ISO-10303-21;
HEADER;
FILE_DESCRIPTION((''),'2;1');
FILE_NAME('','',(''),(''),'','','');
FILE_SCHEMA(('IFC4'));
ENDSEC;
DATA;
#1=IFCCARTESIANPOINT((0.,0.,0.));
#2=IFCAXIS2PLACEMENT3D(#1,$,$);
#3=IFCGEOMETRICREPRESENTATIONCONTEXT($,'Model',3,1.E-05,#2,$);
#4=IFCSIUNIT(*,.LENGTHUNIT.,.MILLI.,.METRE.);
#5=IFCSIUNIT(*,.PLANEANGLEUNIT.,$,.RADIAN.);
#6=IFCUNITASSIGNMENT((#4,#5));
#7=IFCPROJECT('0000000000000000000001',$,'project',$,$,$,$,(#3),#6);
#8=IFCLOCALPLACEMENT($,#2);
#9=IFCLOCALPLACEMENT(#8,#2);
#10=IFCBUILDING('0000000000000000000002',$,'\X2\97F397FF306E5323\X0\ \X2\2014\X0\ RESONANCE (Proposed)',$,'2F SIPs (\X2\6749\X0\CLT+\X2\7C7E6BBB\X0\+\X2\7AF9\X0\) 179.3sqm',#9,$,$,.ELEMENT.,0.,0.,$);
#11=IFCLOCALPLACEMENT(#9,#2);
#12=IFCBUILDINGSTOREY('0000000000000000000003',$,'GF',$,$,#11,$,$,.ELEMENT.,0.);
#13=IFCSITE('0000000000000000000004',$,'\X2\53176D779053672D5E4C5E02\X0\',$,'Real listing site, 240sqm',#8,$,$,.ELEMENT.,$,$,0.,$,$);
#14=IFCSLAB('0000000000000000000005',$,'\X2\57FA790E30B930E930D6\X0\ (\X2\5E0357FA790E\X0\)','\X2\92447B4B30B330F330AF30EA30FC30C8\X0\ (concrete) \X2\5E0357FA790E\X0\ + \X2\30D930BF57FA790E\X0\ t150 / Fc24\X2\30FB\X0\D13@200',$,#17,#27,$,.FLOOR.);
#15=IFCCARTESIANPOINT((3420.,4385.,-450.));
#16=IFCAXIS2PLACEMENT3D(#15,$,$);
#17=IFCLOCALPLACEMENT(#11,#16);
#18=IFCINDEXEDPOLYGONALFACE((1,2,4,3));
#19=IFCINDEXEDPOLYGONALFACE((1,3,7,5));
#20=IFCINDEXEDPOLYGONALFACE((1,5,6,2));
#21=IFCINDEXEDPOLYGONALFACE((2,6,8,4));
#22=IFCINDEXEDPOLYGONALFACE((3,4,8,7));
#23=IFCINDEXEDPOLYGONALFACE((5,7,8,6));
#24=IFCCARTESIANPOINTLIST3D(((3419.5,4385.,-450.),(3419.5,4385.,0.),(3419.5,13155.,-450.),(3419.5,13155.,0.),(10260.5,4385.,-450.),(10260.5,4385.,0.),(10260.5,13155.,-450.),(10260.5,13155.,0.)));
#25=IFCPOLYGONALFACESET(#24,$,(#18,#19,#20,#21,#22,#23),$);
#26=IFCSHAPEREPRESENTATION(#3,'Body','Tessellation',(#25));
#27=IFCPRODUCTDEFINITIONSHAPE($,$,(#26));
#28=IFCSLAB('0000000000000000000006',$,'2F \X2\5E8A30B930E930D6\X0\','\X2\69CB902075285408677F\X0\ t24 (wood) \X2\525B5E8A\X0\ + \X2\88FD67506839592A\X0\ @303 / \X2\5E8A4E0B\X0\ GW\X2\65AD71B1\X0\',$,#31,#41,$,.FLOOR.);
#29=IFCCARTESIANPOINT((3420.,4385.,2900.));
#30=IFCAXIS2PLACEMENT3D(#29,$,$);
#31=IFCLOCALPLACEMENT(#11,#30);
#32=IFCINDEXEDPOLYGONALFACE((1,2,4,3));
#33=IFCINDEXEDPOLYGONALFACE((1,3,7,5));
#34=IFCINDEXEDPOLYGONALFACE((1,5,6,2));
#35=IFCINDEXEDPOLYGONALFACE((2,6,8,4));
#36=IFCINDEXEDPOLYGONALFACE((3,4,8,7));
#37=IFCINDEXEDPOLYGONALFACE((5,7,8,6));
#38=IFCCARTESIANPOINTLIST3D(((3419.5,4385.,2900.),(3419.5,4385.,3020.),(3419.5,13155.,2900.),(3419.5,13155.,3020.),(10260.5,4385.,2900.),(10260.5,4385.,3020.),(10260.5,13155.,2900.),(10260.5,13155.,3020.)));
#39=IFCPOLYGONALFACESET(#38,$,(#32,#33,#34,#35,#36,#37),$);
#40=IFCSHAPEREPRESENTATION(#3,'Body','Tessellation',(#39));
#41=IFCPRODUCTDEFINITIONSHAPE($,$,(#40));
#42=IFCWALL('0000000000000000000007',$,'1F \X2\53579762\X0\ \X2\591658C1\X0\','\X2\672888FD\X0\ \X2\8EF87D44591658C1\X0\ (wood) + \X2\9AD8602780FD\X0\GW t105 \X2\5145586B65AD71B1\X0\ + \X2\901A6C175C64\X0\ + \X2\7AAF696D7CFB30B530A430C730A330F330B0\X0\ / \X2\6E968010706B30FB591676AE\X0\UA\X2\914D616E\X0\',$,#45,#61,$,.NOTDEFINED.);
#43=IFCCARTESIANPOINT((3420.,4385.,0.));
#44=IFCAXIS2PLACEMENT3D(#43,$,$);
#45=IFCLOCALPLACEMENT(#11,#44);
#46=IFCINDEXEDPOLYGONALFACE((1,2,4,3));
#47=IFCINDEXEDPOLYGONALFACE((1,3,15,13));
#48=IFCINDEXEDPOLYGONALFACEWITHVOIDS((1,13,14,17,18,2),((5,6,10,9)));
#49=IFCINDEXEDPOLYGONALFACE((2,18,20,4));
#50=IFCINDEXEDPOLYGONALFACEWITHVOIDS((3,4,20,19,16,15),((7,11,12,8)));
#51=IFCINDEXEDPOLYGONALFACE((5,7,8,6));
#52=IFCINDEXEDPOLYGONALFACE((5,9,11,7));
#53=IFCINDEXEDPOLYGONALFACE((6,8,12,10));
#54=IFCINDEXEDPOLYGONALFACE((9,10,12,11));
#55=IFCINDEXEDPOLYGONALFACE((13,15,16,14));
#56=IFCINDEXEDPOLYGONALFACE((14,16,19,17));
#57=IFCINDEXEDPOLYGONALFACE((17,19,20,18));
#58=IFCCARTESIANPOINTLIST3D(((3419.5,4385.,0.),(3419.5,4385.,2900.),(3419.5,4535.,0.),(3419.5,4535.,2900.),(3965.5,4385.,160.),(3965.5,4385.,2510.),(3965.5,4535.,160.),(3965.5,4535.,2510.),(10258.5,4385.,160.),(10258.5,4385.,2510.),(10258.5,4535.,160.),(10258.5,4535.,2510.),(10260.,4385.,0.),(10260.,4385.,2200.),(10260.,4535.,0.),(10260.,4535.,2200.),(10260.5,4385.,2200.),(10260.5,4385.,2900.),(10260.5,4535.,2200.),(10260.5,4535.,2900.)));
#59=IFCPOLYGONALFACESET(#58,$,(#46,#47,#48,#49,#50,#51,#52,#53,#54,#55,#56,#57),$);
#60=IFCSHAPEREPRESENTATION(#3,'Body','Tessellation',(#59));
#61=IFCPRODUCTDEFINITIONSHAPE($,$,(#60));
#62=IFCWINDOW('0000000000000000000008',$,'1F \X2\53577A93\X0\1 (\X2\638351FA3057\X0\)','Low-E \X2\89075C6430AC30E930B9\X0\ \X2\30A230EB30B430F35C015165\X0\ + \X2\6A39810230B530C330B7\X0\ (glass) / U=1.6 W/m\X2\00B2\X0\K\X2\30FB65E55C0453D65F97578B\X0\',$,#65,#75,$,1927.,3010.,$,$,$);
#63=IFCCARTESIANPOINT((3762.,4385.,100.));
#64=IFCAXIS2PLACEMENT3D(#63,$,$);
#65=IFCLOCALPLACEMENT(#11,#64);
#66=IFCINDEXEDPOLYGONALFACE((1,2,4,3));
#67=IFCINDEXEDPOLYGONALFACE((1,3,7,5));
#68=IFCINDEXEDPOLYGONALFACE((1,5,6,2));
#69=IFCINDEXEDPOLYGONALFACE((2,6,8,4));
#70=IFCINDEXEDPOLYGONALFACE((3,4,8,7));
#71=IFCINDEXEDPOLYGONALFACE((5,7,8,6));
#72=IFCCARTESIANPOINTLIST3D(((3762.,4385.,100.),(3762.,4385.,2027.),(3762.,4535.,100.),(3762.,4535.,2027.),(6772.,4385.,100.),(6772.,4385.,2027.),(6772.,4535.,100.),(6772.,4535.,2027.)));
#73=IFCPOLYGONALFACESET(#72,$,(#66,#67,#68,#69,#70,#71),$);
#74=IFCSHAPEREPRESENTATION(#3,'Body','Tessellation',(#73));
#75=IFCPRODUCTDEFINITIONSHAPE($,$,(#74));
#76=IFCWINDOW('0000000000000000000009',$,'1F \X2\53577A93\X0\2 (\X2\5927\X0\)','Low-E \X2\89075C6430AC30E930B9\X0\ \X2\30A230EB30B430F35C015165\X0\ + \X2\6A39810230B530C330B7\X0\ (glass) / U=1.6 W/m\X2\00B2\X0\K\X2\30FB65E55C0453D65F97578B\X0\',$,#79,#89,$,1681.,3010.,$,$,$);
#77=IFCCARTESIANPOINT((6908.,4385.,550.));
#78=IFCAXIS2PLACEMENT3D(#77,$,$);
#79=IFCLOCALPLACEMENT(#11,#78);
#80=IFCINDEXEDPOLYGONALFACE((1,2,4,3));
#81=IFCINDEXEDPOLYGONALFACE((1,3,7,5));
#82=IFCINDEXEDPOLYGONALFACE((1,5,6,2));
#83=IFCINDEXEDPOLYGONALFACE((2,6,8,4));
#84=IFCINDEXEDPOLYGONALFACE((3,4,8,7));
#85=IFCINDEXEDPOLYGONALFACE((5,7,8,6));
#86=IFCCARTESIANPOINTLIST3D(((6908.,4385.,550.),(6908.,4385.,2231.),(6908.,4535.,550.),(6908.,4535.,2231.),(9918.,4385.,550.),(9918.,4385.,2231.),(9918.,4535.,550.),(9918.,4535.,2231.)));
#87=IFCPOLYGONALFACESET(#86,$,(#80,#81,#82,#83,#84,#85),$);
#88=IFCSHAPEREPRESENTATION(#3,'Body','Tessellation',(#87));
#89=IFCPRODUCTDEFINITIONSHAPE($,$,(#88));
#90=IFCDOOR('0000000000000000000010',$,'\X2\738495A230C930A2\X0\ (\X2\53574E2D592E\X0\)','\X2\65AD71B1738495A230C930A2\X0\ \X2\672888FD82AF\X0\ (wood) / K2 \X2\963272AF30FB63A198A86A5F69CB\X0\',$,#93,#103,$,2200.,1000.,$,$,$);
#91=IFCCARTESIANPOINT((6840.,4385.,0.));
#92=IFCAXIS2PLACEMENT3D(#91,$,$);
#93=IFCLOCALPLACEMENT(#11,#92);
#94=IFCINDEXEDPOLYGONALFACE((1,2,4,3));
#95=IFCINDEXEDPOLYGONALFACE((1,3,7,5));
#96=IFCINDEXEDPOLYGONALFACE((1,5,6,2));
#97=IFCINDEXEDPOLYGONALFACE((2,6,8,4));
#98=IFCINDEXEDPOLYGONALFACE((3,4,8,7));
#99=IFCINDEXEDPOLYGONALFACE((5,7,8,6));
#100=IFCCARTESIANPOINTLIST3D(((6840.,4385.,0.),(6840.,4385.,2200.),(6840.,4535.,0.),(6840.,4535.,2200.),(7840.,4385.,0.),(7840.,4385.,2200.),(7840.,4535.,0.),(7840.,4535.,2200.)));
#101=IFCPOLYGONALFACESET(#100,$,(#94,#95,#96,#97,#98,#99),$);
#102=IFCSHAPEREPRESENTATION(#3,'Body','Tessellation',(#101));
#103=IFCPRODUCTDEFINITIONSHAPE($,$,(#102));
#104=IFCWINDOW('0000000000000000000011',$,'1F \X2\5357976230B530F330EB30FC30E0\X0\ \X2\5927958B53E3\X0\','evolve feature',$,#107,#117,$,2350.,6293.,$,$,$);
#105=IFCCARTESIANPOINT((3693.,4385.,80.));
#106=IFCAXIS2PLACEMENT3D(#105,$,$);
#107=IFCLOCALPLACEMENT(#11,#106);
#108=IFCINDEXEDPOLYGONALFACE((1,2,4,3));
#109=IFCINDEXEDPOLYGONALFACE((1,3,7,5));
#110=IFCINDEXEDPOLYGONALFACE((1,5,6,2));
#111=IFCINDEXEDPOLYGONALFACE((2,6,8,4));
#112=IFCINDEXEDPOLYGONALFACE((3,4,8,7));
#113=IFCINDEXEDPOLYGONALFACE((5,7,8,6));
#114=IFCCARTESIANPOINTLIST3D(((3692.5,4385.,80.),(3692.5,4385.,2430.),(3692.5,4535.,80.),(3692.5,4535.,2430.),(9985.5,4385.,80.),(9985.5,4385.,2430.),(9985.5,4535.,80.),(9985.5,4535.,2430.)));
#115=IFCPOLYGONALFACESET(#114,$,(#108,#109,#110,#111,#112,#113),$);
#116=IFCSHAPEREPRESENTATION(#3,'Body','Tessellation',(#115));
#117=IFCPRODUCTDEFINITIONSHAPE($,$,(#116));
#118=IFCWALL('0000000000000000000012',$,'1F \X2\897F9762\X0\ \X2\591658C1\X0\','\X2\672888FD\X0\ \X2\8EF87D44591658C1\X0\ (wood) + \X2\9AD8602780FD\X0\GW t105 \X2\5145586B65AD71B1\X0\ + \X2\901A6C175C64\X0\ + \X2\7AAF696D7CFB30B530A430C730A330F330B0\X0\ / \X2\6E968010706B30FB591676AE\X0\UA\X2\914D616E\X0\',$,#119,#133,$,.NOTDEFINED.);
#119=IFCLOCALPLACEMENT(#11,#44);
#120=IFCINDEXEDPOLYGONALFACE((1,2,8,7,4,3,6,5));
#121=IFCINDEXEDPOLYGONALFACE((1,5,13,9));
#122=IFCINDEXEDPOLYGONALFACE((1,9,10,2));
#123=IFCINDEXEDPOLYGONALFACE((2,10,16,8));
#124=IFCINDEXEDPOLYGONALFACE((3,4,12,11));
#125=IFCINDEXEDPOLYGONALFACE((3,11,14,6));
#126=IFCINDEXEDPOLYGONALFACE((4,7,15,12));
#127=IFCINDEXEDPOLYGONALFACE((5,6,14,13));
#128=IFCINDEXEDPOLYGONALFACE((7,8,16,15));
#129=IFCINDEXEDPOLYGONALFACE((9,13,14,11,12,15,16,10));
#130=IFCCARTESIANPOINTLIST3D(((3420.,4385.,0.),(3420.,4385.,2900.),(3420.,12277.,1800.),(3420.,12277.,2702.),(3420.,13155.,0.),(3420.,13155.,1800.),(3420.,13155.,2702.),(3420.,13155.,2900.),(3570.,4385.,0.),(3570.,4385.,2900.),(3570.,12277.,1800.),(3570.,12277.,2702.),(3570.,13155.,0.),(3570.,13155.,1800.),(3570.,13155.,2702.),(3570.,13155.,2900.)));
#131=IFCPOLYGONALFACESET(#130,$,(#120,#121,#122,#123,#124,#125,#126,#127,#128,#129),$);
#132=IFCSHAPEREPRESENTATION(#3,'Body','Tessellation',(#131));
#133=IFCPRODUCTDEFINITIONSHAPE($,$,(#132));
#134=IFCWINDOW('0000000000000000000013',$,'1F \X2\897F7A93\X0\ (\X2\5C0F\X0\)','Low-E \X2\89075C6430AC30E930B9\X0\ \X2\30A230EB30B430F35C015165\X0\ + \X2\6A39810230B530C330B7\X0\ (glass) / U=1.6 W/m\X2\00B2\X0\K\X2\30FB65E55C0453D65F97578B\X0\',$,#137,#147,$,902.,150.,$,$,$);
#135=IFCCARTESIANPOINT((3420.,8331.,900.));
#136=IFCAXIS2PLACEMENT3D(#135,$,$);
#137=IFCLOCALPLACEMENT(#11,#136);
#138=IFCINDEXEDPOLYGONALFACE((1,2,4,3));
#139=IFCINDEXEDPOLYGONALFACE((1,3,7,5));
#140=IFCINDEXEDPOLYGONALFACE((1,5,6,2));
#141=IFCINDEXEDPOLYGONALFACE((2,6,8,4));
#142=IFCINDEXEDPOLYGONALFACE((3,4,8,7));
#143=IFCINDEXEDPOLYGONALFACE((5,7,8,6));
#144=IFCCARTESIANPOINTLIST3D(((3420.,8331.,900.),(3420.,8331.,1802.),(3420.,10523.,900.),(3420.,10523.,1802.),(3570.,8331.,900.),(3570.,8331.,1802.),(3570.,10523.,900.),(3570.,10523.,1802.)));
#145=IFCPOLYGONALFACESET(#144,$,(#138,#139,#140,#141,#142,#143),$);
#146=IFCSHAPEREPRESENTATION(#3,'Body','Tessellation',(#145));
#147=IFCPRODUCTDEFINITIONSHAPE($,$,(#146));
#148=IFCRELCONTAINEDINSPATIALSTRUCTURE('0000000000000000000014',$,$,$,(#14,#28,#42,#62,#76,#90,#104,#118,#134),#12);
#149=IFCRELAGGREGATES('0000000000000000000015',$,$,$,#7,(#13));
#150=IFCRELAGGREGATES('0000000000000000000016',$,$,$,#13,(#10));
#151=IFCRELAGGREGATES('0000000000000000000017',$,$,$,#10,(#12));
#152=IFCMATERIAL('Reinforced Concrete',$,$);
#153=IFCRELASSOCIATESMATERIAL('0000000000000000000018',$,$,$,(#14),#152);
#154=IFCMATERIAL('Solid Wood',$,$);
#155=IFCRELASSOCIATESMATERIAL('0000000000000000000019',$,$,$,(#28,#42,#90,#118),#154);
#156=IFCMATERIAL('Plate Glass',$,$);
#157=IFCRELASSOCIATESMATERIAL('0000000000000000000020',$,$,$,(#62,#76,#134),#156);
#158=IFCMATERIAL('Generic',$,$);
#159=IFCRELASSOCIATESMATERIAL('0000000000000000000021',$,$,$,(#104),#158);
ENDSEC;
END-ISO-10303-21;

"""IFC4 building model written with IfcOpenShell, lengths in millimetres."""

from ifc_helpers import new_model, si_unit, frame, frame_2d, origin, place, context, project, spatial, rectangle, extrude, material, element, fill, save


model = new_model("IFC4")

# Units and contexts
model_context = context("Model", 3, precision=1e-05, world=origin())
ifc_project = project(units=[si_unit("LENGTHUNIT", "METRE", prefix="MILLI"), si_unit("PLANEANGLEUNIT", "RADIAN")], contexts=[model_context])

# Site, building, storey
site_placement = place(None, origin())
site = spatial("IfcSite", under=ifc_project, at=site_placement, Name="北海道札幌市", ObjectType="Real listing site, 240sqm", CompositionType="ELEMENT", RefElevation=0.0)
building_placement = place(site_placement, origin())
building = spatial("IfcBuilding", under=site, at=building_placement, Name="音響の匣 — RESONANCE (Proposed)", ObjectType="2F SIPs (杉CLT+籾殻+竹) 179.3sqm", CompositionType="ELEMENT", ElevationOfRefHeight=0.0, ElevationOfTerrain=0.0)
storey_placement = place(building_placement, origin())
storey = spatial("IfcBuildingStorey", under=building, at=storey_placement, Name="GF", CompositionType="ELEMENT", Elevation=0.0)

# Slabs
ifc_material_1 = material(Name="Reinforced Concrete")
slab_1_placement = place(storey_placement, frame((3420.0, 4385.0, -450.0)))
element("IfcSlab", 1, at=slab_1_placement, inside=storey, material=ifc_material_1, Name="基礎スラブ (布基礎)", Description="鉄筋コンクリート (concrete) 布基礎 + ベタ基礎 t150 / Fc24・D13@200", PredefinedType="FLOOR", context=model_context, shape_type="SweptSolid", body=[
    extrude(rectangle(XDim=6841.0, YDim=8770.0, at=frame_2d((3420.0, 4385.0))), frame((3420.0, 4385.0, -450.0)), (0.0, 0.0, 1.0), 450.0),
])
ifc_material_2 = material(Name="Solid Wood")
slab_2_placement = place(storey_placement, frame((3420.0, 4385.0, 2900.0)))
element("IfcSlab", 2, at=slab_2_placement, inside=storey, material=ifc_material_2, Name="2F 床スラブ", Description="構造用合板 t24 (wood) 剛床 + 製材根太 @303 / 床下 GW断熱", PredefinedType="FLOOR", context=model_context, shape_type="SweptSolid", body=[
    extrude(rectangle(XDim=6841.0, YDim=8770.0, at=frame_2d((3420.0, 4385.0))), frame((3420.0, 4385.0, 2900.0)), (0.0, 0.0, 1.0), 120.0),
])

# Wall, openings, windows, door
wall_1_placement = place(storey_placement, frame((3420.0, 4385.0, 0.0)))
wall_1 = element("IfcWall", 3, at=wall_1_placement, inside=storey, material=ifc_material_2, Name="1F 南面 外壁", Description="木製 軸組外壁 (wood) + 高性能GW t105 充填断熱 + 通気層 + 窯業系サイディング / 準耐火・外皮UA配慮", PredefinedType="NOTDEFINED", context=model_context, shape_type="SweptSolid", body=[
    extrude(rectangle(XDim=6841.0, YDim=150.0, at=frame_2d((3420.0, 75.0))), frame((3420.0, 4385.0, 0.0)), (0.0, 0.0, 1.0), 2900.0),
])
opening_1_placement = place(storey_placement, frame((3762.0, 4385.0, 100.0)))
opening_1 = element("IfcOpeningElement", 4, at=opening_1_placement, cuts=wall_1, PredefinedType="NOTDEFINED", context=model_context, shape_type="SweptSolid", body=[
    extrude(rectangle(XDim=3010.0, YDim=150.0, at=frame_2d((1505.0, 75.0))), frame((3762.0, 4385.0, 100.0)), (0.0, 0.0, 1.0), 1927.0),
])
opening_2_placement = place(storey_placement, frame((6908.0, 4385.0, 550.0)))
opening_2 = element("IfcOpeningElement", 5, at=opening_2_placement, cuts=wall_1, PredefinedType="NOTDEFINED", context=model_context, shape_type="SweptSolid", body=[
    extrude(rectangle(XDim=3010.0, YDim=150.0, at=frame_2d((1505.0, 75.0))), frame((6908.0, 4385.0, 550.0)), (0.0, 0.0, 1.0), 1681.0),
])
opening_3_placement = place(storey_placement, frame((6840.0, 4385.0, 0.0)))
opening_3 = element("IfcOpeningElement", 6, at=opening_3_placement, cuts=wall_1, PredefinedType="NOTDEFINED", context=model_context, shape_type="SweptSolid", body=[
    extrude(rectangle(XDim=1000.0, YDim=150.0, at=frame_2d((500.0, 75.0))), frame((6840.0, 4385.0, 0.0)), (0.0, 0.0, 1.0), 2200.0),
])
opening_4_placement = place(storey_placement, frame((3693.0, 4385.0, 80.0)))
opening_4 = element("IfcOpeningElement", 7, at=opening_4_placement, cuts=wall_1, PredefinedType="NOTDEFINED", context=model_context, shape_type="SweptSolid", body=[
    extrude(rectangle(XDim=6293.0, YDim=150.0, at=frame_2d((3146.0, 75.0))), frame((3693.0, 4385.0, 80.0)), (0.0, 0.0, 1.0), 2350.0),
])
ifc_material_3 = material(Name="Plate Glass")
window_1_placement = place(storey_placement, frame((3762.0, 4385.0, 100.0)))
window_1 = element("IfcWindow", 8, at=window_1_placement, inside=storey, material=ifc_material_3, Name="1F 南窓1 (掃出し)", Description="Low-E 複層ガラス アルゴン封入 + 樹脂サッシ (glass) / U=1.6 W/m²K・日射取得型", OverallHeight=1927.0, OverallWidth=3010.0, context=model_context, shape_type="SweptSolid", body=[
    extrude(rectangle(XDim=3010.0, YDim=150.0, at=frame_2d((1505.0, 75.0))), frame((3762.0, 4385.0, 100.0)), (0.0, 0.0, 1.0), 1927.0),
])
fill(opening_1, window_1)
window_2_placement = place(storey_placement, frame((6908.0, 4385.0, 550.0)))
window_2 = element("IfcWindow", 9, at=window_2_placement, inside=storey, material=ifc_material_3, Name="1F 南窓2 (大)", Description="Low-E 複層ガラス アルゴン封入 + 樹脂サッシ (glass) / U=1.6 W/m²K・日射取得型", OverallHeight=1681.0, OverallWidth=3010.0, context=model_context, shape_type="SweptSolid", body=[
    extrude(rectangle(XDim=3010.0, YDim=150.0, at=frame_2d((1505.0, 75.0))), frame((6908.0, 4385.0, 550.0)), (0.0, 0.0, 1.0), 1681.0),
])
fill(opening_2, window_2)
door_placement = place(storey_placement, frame((6840.0, 4385.0, 0.0)))
door = element("IfcDoor", 10, at=door_placement, inside=storey, material=ifc_material_2, Name="玄関ドア (南中央)", Description="断熱玄関ドア 木製芯 (wood) / K2 防犯・採風機構", OverallHeight=2200.0, OverallWidth=1000.0, context=model_context, shape_type="SweptSolid", body=[
    extrude(rectangle(XDim=1000.0, YDim=150.0, at=frame_2d((500.0, 75.0))), frame((6840.0, 4385.0, 0.0)), (0.0, 0.0, 1.0), 2200.0),
])
fill(opening_3, door)
ifc_material_4 = material(Name="Generic")
window_3_placement = place(storey_placement, frame((3693.0, 4385.0, 80.0)))
window_3 = element("IfcWindow", 11, at=window_3_placement, inside=storey, material=ifc_material_4, Name="1F 南面サンルーム 大開口", Description="evolve feature", OverallHeight=2350.0, OverallWidth=6293.0, context=model_context, shape_type="SweptSolid", body=[
    extrude(rectangle(XDim=6293.0, YDim=150.0, at=frame_2d((3146.0, 75.0))), frame((3693.0, 4385.0, 80.0)), (0.0, 0.0, 1.0), 2350.0),
])
fill(opening_4, window_3)

# Wall, opening, window
wall_2_placement = place(storey_placement, frame((3420.0, 4385.0, 0.0)))
wall_2 = element("IfcWall", 12, at=wall_2_placement, inside=storey, material=ifc_material_2, Name="1F 西面 外壁", Description="木製 軸組外壁 (wood) + 高性能GW t105 充填断熱 + 通気層 + 窯業系サイディング / 準耐火・外皮UA配慮", PredefinedType="NOTDEFINED", context=model_context, shape_type="SweptSolid", body=[
    extrude(rectangle(XDim=150.0, YDim=8770.0, at=frame_2d((75.0, 4385.0))), frame((3420.0, 4385.0, 0.0)), (0.0, 0.0, 1.0), 2900.0),
])
opening_5_placement = place(storey_placement, frame((3420.0, 8331.0, 900.0)))
opening_5 = element("IfcOpeningElement", 13, at=opening_5_placement, cuts=wall_2, PredefinedType="NOTDEFINED", context=model_context, shape_type="SweptSolid", body=[
    extrude(rectangle(XDim=150.0, YDim=2192.0, at=frame_2d((75.0, 1096.0))), frame((3420.0, 8331.0, 900.0)), (0.0, 0.0, 1.0), 902.0),
])
window_4_placement = place(storey_placement, frame((3420.0, 8331.0, 900.0)))
window_4 = element("IfcWindow", 14, at=window_4_placement, inside=storey, material=ifc_material_3, Name="1F 西窓 (小)", Description="Low-E 複層ガラス アルゴン封入 + 樹脂サッシ (glass) / U=1.6 W/m²K・日射取得型", OverallHeight=902.0, OverallWidth=150.0, context=model_context, shape_type="SweptSolid", body=[
    extrude(rectangle(XDim=150.0, YDim=2192.0, at=frame_2d((75.0, 1096.0))), frame((3420.0, 8331.0, 900.0)), (0.0, 0.0, 1.0), 902.0),
])
fill(opening_5, window_4)

save(model, "model.ifc")
